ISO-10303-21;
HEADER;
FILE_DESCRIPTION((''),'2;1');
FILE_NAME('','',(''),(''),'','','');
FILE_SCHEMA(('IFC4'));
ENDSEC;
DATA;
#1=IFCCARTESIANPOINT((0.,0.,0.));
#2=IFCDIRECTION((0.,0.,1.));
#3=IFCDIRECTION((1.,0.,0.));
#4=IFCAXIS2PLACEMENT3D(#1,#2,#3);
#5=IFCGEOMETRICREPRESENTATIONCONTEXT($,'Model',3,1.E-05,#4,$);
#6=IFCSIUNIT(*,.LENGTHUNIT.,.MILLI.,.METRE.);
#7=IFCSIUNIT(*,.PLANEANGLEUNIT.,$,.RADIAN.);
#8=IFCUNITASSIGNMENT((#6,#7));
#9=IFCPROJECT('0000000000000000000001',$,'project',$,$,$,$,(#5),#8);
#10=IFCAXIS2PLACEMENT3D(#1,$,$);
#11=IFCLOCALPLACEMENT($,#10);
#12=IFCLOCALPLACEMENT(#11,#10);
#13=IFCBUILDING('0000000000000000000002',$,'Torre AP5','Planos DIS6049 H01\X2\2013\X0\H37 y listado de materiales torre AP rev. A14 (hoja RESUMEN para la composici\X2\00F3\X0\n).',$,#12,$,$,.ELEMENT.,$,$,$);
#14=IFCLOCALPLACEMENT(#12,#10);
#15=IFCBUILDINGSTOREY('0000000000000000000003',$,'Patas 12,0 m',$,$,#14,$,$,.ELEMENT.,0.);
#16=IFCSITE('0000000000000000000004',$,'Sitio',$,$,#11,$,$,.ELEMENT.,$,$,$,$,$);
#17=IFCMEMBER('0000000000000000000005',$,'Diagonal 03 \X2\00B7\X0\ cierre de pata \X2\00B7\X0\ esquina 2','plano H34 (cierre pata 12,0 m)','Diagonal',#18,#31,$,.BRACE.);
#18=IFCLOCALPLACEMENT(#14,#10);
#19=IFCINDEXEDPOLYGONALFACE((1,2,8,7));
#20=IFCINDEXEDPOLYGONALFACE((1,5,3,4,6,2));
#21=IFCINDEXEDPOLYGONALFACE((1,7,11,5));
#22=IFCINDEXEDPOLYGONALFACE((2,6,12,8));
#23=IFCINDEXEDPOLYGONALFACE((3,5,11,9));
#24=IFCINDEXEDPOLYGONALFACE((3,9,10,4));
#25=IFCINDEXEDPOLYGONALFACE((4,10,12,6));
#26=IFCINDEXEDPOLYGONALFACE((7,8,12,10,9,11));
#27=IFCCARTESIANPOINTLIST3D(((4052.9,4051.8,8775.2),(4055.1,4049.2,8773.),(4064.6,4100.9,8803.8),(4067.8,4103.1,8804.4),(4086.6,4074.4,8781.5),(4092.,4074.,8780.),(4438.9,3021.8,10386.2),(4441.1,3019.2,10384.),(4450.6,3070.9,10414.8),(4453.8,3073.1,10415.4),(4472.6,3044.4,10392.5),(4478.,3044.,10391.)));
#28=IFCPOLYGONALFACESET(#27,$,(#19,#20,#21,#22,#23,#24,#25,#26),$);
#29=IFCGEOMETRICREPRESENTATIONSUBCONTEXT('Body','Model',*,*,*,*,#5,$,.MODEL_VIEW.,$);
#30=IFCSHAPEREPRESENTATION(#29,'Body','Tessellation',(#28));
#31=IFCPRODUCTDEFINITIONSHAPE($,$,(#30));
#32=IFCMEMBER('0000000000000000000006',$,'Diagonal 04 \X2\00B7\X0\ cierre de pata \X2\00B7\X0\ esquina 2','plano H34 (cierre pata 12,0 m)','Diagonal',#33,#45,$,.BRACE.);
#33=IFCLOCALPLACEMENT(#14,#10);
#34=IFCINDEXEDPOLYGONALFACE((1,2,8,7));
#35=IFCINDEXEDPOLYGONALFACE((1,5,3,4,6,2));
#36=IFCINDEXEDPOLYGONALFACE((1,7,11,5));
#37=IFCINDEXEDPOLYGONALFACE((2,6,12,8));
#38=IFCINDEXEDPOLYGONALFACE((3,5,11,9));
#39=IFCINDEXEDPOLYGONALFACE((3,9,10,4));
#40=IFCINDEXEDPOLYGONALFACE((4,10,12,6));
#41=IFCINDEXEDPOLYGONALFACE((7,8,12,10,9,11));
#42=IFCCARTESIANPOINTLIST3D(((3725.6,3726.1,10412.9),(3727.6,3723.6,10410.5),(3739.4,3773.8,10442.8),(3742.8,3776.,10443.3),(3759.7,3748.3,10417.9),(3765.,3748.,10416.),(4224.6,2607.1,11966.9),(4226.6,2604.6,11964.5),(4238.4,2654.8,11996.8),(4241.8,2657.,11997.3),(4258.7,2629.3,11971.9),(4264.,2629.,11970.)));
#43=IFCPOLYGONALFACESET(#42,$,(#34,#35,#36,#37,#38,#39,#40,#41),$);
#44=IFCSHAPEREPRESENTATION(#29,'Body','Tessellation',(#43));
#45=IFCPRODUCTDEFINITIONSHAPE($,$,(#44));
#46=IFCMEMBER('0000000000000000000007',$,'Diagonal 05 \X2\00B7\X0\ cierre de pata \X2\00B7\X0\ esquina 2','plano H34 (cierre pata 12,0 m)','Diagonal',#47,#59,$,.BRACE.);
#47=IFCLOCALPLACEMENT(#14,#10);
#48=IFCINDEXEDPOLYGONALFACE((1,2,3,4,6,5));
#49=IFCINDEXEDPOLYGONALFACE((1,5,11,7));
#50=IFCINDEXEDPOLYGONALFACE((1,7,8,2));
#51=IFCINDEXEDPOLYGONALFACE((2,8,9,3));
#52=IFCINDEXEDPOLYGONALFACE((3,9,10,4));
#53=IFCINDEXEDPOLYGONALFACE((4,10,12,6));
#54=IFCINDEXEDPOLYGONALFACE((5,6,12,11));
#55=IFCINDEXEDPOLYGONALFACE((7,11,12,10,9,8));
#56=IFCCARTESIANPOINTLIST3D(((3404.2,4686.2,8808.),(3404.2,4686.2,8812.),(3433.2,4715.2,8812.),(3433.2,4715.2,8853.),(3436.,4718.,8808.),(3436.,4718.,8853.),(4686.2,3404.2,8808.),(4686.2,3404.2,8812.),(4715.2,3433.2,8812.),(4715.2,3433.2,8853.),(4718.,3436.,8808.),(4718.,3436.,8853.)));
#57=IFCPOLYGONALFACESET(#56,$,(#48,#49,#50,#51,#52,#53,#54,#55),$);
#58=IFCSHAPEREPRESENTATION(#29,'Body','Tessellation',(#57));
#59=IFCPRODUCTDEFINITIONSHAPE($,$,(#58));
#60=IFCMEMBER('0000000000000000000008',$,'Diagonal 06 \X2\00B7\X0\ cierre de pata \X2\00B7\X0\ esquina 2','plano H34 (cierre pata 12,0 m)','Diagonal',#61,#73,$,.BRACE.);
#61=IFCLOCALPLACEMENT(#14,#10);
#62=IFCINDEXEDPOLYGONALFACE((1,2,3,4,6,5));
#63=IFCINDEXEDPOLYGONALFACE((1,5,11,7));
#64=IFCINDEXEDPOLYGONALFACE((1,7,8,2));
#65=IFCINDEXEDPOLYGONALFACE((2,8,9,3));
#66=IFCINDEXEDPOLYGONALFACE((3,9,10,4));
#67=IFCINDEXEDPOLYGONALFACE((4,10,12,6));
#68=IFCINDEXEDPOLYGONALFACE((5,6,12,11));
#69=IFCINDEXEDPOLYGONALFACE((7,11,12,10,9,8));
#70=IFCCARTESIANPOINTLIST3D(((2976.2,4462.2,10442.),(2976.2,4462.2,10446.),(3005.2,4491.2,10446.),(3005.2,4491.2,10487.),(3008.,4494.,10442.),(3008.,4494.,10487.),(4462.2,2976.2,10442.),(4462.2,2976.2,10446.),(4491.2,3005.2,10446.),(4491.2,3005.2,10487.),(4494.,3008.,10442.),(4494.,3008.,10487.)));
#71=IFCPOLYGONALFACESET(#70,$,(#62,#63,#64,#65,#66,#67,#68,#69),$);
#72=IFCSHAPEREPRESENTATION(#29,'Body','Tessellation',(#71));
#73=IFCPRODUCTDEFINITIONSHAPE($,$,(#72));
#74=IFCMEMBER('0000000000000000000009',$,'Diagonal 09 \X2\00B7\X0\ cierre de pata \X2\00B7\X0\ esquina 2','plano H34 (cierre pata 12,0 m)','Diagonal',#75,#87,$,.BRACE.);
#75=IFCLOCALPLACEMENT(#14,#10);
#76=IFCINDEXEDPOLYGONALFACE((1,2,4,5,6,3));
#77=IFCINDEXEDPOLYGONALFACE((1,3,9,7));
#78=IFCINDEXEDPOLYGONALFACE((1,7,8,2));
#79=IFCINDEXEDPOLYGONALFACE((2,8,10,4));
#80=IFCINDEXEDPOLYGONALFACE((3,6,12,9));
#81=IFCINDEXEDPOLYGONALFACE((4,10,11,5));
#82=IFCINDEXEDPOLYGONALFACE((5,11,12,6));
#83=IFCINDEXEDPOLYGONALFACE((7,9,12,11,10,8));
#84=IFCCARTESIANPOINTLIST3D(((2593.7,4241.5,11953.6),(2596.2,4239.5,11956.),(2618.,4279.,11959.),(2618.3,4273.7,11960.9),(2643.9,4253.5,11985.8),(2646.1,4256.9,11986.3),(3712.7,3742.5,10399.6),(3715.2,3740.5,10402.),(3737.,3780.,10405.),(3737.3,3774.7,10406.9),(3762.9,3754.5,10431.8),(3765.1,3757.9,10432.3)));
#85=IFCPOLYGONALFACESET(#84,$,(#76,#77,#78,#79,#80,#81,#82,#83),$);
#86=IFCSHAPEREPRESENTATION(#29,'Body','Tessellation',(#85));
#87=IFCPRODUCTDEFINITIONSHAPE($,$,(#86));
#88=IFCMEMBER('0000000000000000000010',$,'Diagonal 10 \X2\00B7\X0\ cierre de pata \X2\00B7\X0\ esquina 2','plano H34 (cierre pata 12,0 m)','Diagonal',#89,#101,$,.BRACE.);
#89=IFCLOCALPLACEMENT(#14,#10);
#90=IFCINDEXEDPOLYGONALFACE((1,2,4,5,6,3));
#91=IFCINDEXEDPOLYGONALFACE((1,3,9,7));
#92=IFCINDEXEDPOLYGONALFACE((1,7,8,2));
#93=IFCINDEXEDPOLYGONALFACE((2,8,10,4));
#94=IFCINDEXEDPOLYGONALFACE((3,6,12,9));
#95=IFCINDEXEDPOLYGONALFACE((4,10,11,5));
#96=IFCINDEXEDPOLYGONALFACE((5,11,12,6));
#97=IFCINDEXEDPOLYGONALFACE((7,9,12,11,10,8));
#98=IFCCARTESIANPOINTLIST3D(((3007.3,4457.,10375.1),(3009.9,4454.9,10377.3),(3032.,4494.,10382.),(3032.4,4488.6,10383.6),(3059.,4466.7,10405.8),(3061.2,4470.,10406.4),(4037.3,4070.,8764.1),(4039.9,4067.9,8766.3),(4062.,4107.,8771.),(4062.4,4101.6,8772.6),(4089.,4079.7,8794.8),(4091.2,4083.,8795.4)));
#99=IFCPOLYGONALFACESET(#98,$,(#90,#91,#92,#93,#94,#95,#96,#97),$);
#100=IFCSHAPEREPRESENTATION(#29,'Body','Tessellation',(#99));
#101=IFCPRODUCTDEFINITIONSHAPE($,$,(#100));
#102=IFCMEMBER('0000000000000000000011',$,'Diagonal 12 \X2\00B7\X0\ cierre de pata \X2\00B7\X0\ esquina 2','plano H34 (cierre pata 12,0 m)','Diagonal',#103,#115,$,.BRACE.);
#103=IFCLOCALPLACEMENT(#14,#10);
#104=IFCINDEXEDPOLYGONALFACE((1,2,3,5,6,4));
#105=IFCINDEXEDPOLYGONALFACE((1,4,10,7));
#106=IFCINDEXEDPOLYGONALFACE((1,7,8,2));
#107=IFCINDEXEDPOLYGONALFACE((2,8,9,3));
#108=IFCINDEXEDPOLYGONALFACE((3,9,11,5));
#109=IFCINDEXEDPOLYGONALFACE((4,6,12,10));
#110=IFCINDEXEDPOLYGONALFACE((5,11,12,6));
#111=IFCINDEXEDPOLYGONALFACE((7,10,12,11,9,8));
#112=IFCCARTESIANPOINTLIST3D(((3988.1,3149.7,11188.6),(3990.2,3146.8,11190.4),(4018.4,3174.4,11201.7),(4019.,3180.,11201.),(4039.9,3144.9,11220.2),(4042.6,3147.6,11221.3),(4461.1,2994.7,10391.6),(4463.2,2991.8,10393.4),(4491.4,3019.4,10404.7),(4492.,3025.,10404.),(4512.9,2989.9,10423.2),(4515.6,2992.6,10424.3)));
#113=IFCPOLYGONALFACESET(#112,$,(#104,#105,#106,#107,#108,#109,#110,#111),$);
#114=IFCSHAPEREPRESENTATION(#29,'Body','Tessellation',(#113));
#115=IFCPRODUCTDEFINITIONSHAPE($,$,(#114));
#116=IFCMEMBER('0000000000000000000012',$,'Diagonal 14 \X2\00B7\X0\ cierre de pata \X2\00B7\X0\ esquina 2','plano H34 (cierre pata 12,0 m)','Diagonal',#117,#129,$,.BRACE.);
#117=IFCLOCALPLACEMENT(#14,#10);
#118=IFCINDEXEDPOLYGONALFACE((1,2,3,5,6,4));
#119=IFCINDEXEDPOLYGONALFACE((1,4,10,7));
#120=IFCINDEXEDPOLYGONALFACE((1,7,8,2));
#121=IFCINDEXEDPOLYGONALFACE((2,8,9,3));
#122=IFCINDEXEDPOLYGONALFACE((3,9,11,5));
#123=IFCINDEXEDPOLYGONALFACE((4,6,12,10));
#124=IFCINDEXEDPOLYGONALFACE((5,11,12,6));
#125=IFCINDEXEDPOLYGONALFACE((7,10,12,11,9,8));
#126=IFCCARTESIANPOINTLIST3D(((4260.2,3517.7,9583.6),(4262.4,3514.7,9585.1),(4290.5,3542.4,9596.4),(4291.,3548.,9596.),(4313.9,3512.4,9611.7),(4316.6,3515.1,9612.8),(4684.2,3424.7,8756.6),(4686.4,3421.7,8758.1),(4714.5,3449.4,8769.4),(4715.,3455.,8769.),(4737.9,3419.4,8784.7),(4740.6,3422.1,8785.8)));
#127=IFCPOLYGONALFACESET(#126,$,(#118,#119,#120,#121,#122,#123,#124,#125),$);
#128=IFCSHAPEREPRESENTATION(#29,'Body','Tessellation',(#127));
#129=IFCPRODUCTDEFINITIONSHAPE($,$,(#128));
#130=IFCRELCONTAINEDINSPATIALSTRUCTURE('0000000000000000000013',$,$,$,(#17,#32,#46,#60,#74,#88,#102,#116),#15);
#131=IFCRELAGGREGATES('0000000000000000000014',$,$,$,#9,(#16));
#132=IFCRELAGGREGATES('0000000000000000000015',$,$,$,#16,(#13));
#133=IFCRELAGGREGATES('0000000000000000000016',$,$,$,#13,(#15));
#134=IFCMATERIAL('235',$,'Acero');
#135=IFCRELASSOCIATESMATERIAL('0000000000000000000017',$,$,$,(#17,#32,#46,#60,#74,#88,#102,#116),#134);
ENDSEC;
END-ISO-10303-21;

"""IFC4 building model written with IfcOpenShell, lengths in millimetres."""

from ifc_helpers import new_model, si_unit, frame, frame_2d, origin, origin_with_axes, place, context, subcontext, project, spatial, l_section, extrude, material, element, save


model = new_model("IFC4")

# Units and contexts
model_context = context("Model", 3, precision=1e-05, world=origin_with_axes())
body_context = subcontext(model_context, "Body", "Model", "MODEL_VIEW")
ifc_project = project(units=[si_unit("LENGTHUNIT", "METRE", prefix="MILLI"), si_unit("PLANEANGLEUNIT", "RADIAN")], contexts=[model_context])

# Site, building, storey
site_placement = place(None, origin())
site = spatial("IfcSite", under=ifc_project, at=site_placement, Name="Sitio", CompositionType="ELEMENT")
building_placement = place(site_placement, origin())
building = spatial("IfcBuilding", under=site, at=building_placement, Name="Torre AP5", Description="Planos DIS6049 H01–H37 y listado de materiales torre AP rev. A14 (hoja RESUMEN para la composición).", CompositionType="ELEMENT")
storey_placement = place(building_placement, origin())
storey = spatial("IfcBuildingStorey", under=building, at=storey_placement, Name="Patas 12,0 m", CompositionType="ELEMENT", Elevation=0.0)

# Members
ifc_material_1 = material(Name="235", Category="Acero")
member_1_placement = place(storey_placement, frame((4478.0, 3044.0, 10391.0), z_axis=(-0.197878, 0.528017, -0.825859), x_axis=(-0.820079, -0.550691, -0.155594)))
element("IfcMember", 1, at=member_1_placement, inside=storey, material=ifc_material_1, Name="Diagonal 03 · cierre de pata · esquina 2", Description="plano H34 (cierre pata 12,0 m)", ObjectType="Diagonal", PredefinedType="BRACE", context=body_context, shape_type="SweptSolid", body=[
    extrude(l_section(Depth=45.0, Width=45.0, Thickness=4.0, at=frame_2d((22.5, 22.5))), None, (0.0, 0.0, 1.0), 1950.7),
])
member_2_placement = place(storey_placement, frame((4264.0, 2629.0, 11970.0), z_axis=(-0.252159, 0.565463, -0.785281), x_axis=(-0.831906, -0.541208, -0.122581)))
element("IfcMember", 2, at=member_2_placement, inside=storey, material=ifc_material_1, Name="Diagonal 04 · cierre de pata · esquina 2", Description="plano H34 (cierre pata 12,0 m)", ObjectType="Diagonal", PredefinedType="BRACE", context=body_context, shape_type="SweptSolid", body=[
    extrude(l_section(Depth=45.0, Width=45.0, Thickness=4.0, at=frame_2d((22.5, 22.5))), None, (0.0, 0.0, 1.0), 1978.9),
])
member_3_placement = place(storey_placement, frame((4718.0, 3436.0, 8808.0), z_axis=(-0.707107, 0.707107, 0.0), x_axis=(-0.707107, -0.707107, 0.0)))
element("IfcMember", 3, at=member_3_placement, inside=storey, material=ifc_material_1, Name="Diagonal 05 · cierre de pata · esquina 2", Description="plano H34 (cierre pata 12,0 m)", ObjectType="Diagonal", PredefinedType="BRACE", context=body_context, shape_type="SweptSolid", body=[
    extrude(l_section(Depth=45.0, Width=45.0, Thickness=4.0, at=frame_2d((22.5, 22.5))), None, (0.0, 0.0, 1.0), 1813.0),
])
member_4_placement = place(storey_placement, frame((4494.0, 3008.0, 10442.0), z_axis=(-0.707107, 0.707107, 0.0), x_axis=(-0.707107, -0.707107, 0.0)))
element("IfcMember", 4, at=member_4_placement, inside=storey, material=ifc_material_1, Name="Diagonal 06 · cierre de pata · esquina 2", Description="plano H34 (cierre pata 12,0 m)", ObjectType="Diagonal", PredefinedType="BRACE", context=body_context, shape_type="SweptSolid", body=[
    extrude(l_section(Depth=45.0, Width=45.0, Thickness=4.0, at=frame_2d((22.5, 22.5))), None, (0.0, 0.0, 1.0), 2101.5),
])
member_5_placement = place(storey_placement, frame((3737.0, 3780.0, 10405.0), z_axis=(-0.565463, 0.252159, 0.785281), x_axis=(-0.539456, -0.833293, -0.120874)))
element("IfcMember", 5, at=member_5_placement, inside=storey, material=ifc_material_1, Name="Diagonal 09 · cierre de pata · esquina 2", Description="plano H34 (cierre pata 12,0 m)", ObjectType="Diagonal", PredefinedType="BRACE", context=body_context, shape_type="SweptSolid", body=[
    extrude(l_section(Depth=45.0, Width=45.0, Thickness=4.0, at=frame_2d((22.5, 22.5))), None, (0.0, 0.0, 1.0), 1978.9),
])
member_6_placement = place(storey_placement, frame((4062.0, 4107.0, 8771.0), z_axis=(-0.527963, 0.198371, 0.825775), x_axis=(-0.548981, -0.821595, -0.153627)))
element("IfcMember", 6, at=member_6_placement, inside=storey, material=ifc_material_1, Name="Diagonal 10 · cierre de pata · esquina 2", Description="plano H34 (cierre pata 12,0 m)", ObjectType="Diagonal", PredefinedType="BRACE", context=body_context, shape_type="SweptSolid", body=[
    extrude(l_section(Depth=45.0, Width=45.0, Thickness=4.0, at=frame_2d((22.5, 22.5))), None, (0.0, 0.0, 1.0), 1950.9),
])
member_7_placement = place(storey_placement, frame((4492.0, 3025.0, 10404.0), z_axis=(-0.503373, 0.164953, 0.848178), x_axis=(-0.685914, -0.673253, -0.276139)))
element("IfcMember", 7, at=member_7_placement, inside=storey, material=ifc_material_1, Name="Diagonal 12 · cierre de pata · esquina 2", Description="plano H34 (cierre pata 12,0 m)", ObjectType="Diagonal", PredefinedType="BRACE", context=body_context, shape_type="SweptSolid", body=[
    extrude(l_section(Depth=45.0, Width=45.0, Thickness=4.0, at=frame_2d((22.5, 22.5))), None, (0.0, 0.0, 1.0), 939.7),
])
member_8_placement = place(storey_placement, frame((4715.0, 3455.0, 8769.0), z_axis=(-0.453962, 0.099572, 0.88544), x_axis=(-0.685467, -0.673907, -0.275653)))
element("IfcMember", 8, at=member_8_placement, inside=storey, material=ifc_material_1, Name="Diagonal 14 · cierre de pata · esquina 2", Description="plano H34 (cierre pata 12,0 m)", ObjectType="Diagonal", PredefinedType="BRACE", context=body_context, shape_type="SweptSolid", body=[
    extrude(l_section(Depth=45.0, Width=45.0, Thickness=4.0, at=frame_2d((22.5, 22.5))), None, (0.0, 0.0, 1.0), 934.0),
])

save(model, "model.ifc")
